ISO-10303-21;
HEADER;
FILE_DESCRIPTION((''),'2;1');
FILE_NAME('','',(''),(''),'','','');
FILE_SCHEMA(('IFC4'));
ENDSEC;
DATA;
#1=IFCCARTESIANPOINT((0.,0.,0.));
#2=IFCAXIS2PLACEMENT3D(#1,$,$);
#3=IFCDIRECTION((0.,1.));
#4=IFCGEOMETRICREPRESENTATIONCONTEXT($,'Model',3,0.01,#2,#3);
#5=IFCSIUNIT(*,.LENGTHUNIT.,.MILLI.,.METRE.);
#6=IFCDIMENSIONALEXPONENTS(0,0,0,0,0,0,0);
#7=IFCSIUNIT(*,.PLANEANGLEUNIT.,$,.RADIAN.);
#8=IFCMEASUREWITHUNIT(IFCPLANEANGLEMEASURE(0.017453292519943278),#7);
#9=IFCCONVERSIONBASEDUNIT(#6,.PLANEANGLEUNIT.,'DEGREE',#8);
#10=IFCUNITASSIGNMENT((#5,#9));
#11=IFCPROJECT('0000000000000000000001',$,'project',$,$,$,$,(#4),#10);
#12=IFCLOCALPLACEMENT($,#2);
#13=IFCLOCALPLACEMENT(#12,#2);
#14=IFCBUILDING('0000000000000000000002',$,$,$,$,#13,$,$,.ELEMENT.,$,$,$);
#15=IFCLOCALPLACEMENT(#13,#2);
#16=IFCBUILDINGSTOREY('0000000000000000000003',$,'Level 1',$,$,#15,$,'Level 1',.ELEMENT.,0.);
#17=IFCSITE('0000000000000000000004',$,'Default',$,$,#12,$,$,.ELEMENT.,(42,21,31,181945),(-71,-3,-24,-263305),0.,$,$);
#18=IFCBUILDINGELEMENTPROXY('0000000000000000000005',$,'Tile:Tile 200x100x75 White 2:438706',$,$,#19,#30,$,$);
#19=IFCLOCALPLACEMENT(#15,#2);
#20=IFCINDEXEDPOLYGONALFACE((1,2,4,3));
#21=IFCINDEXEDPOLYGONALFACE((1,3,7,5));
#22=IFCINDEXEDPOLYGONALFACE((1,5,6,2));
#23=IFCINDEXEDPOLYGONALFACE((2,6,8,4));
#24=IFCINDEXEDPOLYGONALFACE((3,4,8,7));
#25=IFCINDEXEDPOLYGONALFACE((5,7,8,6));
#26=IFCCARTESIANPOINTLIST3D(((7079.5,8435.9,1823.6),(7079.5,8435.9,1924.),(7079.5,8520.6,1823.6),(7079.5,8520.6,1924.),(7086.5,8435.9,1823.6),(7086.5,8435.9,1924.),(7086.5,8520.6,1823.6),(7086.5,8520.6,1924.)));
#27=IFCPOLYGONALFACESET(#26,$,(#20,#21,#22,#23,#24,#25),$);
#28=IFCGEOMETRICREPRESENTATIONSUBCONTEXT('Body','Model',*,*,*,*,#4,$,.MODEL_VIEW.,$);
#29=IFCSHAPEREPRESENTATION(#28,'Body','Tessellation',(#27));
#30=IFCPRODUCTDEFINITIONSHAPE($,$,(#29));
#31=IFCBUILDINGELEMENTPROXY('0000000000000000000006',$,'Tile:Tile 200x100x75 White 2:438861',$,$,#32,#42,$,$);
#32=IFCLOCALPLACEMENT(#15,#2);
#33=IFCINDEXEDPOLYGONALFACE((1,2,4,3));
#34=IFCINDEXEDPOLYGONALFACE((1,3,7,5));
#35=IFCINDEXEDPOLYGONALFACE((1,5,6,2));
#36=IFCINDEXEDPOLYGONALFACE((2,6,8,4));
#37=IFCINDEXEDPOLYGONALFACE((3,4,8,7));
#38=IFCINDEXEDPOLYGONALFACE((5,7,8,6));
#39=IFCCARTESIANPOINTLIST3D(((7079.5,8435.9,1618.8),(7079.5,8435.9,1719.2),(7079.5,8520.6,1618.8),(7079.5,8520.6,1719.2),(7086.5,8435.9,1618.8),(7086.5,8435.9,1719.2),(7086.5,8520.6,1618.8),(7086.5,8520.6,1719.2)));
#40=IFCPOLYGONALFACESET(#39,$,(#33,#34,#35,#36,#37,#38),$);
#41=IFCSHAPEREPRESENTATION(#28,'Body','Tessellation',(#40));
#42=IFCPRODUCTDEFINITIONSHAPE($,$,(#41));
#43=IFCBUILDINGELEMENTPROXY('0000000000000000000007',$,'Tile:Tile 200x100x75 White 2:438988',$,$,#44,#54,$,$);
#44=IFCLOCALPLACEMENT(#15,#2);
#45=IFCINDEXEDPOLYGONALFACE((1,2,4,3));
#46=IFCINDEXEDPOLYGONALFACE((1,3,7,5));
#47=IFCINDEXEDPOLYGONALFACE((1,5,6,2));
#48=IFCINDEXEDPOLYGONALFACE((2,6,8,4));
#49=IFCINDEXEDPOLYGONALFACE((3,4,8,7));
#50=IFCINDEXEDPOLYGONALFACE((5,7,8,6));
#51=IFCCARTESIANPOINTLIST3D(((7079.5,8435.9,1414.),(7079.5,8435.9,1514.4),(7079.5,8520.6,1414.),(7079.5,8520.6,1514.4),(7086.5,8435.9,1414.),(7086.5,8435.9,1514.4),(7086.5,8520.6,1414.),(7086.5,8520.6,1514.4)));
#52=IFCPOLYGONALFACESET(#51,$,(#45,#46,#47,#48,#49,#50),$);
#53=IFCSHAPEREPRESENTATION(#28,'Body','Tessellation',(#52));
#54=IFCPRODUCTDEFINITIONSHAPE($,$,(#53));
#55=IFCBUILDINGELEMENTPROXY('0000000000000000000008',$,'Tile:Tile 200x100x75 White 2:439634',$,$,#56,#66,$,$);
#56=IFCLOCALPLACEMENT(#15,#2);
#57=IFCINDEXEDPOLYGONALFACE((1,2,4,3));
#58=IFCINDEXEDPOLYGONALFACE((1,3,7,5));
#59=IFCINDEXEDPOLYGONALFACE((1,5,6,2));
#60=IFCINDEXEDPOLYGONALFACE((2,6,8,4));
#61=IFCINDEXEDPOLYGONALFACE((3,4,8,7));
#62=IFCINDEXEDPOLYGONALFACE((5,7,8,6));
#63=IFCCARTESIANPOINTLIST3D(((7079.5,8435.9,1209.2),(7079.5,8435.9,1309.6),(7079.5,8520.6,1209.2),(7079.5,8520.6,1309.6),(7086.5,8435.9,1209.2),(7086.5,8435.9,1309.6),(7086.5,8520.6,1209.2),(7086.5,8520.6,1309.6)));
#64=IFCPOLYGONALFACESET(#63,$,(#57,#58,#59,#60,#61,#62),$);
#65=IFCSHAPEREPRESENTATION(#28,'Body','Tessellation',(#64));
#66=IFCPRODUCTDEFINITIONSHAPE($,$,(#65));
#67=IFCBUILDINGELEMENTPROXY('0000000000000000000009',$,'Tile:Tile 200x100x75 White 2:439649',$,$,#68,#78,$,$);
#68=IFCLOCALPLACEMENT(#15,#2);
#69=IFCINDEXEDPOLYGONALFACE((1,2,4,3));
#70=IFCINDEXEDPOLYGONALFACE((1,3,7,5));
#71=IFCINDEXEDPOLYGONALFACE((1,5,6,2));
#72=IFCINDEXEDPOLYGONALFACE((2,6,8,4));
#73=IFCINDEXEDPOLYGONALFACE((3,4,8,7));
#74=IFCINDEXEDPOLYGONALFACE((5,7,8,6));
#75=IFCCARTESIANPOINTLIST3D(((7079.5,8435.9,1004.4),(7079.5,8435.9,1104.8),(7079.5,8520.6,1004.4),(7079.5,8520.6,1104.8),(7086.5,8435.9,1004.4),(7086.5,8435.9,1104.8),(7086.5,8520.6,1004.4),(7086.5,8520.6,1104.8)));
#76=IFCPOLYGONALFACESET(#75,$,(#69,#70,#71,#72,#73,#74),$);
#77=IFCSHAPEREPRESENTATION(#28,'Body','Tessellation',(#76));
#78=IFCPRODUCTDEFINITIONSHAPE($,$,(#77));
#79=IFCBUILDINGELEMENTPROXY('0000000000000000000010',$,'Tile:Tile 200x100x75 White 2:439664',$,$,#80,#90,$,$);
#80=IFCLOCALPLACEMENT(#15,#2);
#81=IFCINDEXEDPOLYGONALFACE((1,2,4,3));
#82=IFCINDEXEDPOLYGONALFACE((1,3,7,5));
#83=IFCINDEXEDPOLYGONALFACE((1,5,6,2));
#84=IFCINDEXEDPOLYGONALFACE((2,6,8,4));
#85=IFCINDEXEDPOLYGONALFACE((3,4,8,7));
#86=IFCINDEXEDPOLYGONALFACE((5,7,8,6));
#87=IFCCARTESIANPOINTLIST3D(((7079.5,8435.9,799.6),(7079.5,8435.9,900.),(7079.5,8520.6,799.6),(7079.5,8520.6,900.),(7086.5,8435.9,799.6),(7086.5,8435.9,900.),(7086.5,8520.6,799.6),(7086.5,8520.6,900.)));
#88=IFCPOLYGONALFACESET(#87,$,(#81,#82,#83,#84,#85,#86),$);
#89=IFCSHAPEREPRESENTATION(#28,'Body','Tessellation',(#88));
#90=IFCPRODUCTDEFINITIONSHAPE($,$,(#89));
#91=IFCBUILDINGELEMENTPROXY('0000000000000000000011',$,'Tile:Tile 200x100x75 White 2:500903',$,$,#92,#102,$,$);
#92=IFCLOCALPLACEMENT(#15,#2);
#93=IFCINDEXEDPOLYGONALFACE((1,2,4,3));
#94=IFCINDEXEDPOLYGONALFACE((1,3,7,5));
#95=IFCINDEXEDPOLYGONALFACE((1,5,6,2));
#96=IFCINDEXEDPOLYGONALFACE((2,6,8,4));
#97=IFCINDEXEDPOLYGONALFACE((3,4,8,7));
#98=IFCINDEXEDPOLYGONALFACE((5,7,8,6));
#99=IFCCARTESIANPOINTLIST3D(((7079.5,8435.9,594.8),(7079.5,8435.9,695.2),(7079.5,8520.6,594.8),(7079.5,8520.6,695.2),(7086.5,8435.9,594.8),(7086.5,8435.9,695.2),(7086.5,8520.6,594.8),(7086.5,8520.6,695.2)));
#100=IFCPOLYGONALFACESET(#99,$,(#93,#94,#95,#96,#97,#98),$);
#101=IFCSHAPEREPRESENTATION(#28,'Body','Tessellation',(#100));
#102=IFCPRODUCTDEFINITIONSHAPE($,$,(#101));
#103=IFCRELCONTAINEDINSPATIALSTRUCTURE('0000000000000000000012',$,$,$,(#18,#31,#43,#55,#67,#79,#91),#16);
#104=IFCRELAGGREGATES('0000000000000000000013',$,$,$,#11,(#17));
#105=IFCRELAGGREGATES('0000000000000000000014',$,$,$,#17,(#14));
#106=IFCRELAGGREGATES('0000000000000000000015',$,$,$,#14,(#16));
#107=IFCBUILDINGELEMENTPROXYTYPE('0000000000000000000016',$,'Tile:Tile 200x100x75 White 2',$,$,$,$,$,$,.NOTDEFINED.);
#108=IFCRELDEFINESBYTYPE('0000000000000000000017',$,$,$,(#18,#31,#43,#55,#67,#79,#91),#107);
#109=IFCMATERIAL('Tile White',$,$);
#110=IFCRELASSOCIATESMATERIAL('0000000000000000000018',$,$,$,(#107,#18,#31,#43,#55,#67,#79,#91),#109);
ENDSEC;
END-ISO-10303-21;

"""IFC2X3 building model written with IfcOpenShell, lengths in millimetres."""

from ifc_helpers import new_model, entity, si_unit, converted_unit, direction, frame, frame_2d, origin, place, context, subcontext, project, spatial, rectangle, extrude, source, transform, mapped, material, type_object, type_shapes, element, save


model = new_model("IFC2X3")

# Units and contexts
model_context = context("Model", 3, precision=0.01, world=origin(), true_north=direction((0.0, 1.0)))
body_context = subcontext(model_context, "Body", "Model", "MODEL_VIEW")
ifc_project = project(units=[si_unit("LENGTHUNIT", "METRE", prefix="MILLI"), converted_unit("PLANEANGLEUNIT", "DEGREE", entity("IfcPlaneAngleMeasure", 0.017453292519943278), si_unit("PLANEANGLEUNIT", "RADIAN"), dimensions=[0, 0, 0, 0, 0, 0, 0])], contexts=[model_context])

# Site, building, storey
site_placement = place(None, origin())
site = spatial("IfcSite", under=ifc_project, at=site_placement, Name="Default", CompositionType="ELEMENT", RefLatitude=(42, 21, 31, 181945), RefLongitude=(-71, -3, -24, -263305), RefElevation=0.0)
building_placement = place(site_placement, origin())
building = spatial("IfcBuilding", under=site, at=building_placement, CompositionType="ELEMENT")
storey_placement = place(building_placement, origin())
storey = spatial("IfcBuildingStorey", under=building, at=storey_placement, Name="Level 1", LongName="Level 1", CompositionType="ELEMENT", Elevation=0.0)

# Building element proxies
ifc_material_1 = material(Name="Tile White")
building_element_proxy_type_1 = type_object("IfcBuildingElementProxyType", Name="Tile:Tile 200x100x75 White 2", PredefinedType="NOTDEFINED", material=ifc_material_1)
shared_shape_1 = source(origin(), body_context, "Body", "SweptSolid", [
    extrude(rectangle(XDim=84.7, YDim=100.4, at=frame_2d((0.0, 0.0), x_axis=(1.0, 0.0))), frame((-50.2, -42.4, 0.0), z_axis=(0.0, 0.0, 1.0), x_axis=(0.0, -1.0, 0.0)), (0.0, 0.0, 1.0), 7.0),
])
type_shapes(building_element_proxy_type_1, [shared_shape_1])
for number, where, z_axis, x_axis, name in (
    (1, (7086.5, 8520.6, 1924.0), (-1.0, 0.0, 0.0), (0.0, 0.0, 1.0), "Tile:Tile 200x100x75 White 2:438706"),
    (2, (7086.5, 8520.6, 1719.2), (-1.0, 0.0, 0.0), (0.0, 0.0, 1.0), "Tile:Tile 200x100x75 White 2:438861"),
    (3, (7086.5, 8520.6, 1514.4), (-1.0, 0.0, 0.0), (0.0, 0.0, 1.0), "Tile:Tile 200x100x75 White 2:438988"),
    (4, (7086.5, 8520.6, 1309.6), (-1.0, 0.0, 0.0), (0.0, 0.0, 1.0), "Tile:Tile 200x100x75 White 2:439634"),
    (5, (7086.5, 8520.6, 1104.8), (-1.0, 0.0, 0.0), (0.0, 0.0, 1.0), "Tile:Tile 200x100x75 White 2:439649"),
    (6, (7086.5, 8520.6, 900.0), (-1.0, 0.0, 0.0), (0.0, 0.0, 1.0), "Tile:Tile 200x100x75 White 2:439664"),
    (7, (7086.5, 8520.6, 695.2), (-1.0, 0.0, 0.0), (0.0, 0.0, 1.0), "Tile:Tile 200x100x75 White 2:500903"),
):
    element("IfcBuildingElementProxy", number, at=place(storey_placement, frame(where, z_axis=z_axis, x_axis=x_axis)), inside=storey, type_object=building_element_proxy_type_1, material=ifc_material_1, Name=name, context=body_context, shape_type="MappedRepresentation", body=[
        mapped(shared_shape_1, transform((0.0, 0.0, 0.0), scale=1.0)),
    ])

save(model, "model.ifc")
